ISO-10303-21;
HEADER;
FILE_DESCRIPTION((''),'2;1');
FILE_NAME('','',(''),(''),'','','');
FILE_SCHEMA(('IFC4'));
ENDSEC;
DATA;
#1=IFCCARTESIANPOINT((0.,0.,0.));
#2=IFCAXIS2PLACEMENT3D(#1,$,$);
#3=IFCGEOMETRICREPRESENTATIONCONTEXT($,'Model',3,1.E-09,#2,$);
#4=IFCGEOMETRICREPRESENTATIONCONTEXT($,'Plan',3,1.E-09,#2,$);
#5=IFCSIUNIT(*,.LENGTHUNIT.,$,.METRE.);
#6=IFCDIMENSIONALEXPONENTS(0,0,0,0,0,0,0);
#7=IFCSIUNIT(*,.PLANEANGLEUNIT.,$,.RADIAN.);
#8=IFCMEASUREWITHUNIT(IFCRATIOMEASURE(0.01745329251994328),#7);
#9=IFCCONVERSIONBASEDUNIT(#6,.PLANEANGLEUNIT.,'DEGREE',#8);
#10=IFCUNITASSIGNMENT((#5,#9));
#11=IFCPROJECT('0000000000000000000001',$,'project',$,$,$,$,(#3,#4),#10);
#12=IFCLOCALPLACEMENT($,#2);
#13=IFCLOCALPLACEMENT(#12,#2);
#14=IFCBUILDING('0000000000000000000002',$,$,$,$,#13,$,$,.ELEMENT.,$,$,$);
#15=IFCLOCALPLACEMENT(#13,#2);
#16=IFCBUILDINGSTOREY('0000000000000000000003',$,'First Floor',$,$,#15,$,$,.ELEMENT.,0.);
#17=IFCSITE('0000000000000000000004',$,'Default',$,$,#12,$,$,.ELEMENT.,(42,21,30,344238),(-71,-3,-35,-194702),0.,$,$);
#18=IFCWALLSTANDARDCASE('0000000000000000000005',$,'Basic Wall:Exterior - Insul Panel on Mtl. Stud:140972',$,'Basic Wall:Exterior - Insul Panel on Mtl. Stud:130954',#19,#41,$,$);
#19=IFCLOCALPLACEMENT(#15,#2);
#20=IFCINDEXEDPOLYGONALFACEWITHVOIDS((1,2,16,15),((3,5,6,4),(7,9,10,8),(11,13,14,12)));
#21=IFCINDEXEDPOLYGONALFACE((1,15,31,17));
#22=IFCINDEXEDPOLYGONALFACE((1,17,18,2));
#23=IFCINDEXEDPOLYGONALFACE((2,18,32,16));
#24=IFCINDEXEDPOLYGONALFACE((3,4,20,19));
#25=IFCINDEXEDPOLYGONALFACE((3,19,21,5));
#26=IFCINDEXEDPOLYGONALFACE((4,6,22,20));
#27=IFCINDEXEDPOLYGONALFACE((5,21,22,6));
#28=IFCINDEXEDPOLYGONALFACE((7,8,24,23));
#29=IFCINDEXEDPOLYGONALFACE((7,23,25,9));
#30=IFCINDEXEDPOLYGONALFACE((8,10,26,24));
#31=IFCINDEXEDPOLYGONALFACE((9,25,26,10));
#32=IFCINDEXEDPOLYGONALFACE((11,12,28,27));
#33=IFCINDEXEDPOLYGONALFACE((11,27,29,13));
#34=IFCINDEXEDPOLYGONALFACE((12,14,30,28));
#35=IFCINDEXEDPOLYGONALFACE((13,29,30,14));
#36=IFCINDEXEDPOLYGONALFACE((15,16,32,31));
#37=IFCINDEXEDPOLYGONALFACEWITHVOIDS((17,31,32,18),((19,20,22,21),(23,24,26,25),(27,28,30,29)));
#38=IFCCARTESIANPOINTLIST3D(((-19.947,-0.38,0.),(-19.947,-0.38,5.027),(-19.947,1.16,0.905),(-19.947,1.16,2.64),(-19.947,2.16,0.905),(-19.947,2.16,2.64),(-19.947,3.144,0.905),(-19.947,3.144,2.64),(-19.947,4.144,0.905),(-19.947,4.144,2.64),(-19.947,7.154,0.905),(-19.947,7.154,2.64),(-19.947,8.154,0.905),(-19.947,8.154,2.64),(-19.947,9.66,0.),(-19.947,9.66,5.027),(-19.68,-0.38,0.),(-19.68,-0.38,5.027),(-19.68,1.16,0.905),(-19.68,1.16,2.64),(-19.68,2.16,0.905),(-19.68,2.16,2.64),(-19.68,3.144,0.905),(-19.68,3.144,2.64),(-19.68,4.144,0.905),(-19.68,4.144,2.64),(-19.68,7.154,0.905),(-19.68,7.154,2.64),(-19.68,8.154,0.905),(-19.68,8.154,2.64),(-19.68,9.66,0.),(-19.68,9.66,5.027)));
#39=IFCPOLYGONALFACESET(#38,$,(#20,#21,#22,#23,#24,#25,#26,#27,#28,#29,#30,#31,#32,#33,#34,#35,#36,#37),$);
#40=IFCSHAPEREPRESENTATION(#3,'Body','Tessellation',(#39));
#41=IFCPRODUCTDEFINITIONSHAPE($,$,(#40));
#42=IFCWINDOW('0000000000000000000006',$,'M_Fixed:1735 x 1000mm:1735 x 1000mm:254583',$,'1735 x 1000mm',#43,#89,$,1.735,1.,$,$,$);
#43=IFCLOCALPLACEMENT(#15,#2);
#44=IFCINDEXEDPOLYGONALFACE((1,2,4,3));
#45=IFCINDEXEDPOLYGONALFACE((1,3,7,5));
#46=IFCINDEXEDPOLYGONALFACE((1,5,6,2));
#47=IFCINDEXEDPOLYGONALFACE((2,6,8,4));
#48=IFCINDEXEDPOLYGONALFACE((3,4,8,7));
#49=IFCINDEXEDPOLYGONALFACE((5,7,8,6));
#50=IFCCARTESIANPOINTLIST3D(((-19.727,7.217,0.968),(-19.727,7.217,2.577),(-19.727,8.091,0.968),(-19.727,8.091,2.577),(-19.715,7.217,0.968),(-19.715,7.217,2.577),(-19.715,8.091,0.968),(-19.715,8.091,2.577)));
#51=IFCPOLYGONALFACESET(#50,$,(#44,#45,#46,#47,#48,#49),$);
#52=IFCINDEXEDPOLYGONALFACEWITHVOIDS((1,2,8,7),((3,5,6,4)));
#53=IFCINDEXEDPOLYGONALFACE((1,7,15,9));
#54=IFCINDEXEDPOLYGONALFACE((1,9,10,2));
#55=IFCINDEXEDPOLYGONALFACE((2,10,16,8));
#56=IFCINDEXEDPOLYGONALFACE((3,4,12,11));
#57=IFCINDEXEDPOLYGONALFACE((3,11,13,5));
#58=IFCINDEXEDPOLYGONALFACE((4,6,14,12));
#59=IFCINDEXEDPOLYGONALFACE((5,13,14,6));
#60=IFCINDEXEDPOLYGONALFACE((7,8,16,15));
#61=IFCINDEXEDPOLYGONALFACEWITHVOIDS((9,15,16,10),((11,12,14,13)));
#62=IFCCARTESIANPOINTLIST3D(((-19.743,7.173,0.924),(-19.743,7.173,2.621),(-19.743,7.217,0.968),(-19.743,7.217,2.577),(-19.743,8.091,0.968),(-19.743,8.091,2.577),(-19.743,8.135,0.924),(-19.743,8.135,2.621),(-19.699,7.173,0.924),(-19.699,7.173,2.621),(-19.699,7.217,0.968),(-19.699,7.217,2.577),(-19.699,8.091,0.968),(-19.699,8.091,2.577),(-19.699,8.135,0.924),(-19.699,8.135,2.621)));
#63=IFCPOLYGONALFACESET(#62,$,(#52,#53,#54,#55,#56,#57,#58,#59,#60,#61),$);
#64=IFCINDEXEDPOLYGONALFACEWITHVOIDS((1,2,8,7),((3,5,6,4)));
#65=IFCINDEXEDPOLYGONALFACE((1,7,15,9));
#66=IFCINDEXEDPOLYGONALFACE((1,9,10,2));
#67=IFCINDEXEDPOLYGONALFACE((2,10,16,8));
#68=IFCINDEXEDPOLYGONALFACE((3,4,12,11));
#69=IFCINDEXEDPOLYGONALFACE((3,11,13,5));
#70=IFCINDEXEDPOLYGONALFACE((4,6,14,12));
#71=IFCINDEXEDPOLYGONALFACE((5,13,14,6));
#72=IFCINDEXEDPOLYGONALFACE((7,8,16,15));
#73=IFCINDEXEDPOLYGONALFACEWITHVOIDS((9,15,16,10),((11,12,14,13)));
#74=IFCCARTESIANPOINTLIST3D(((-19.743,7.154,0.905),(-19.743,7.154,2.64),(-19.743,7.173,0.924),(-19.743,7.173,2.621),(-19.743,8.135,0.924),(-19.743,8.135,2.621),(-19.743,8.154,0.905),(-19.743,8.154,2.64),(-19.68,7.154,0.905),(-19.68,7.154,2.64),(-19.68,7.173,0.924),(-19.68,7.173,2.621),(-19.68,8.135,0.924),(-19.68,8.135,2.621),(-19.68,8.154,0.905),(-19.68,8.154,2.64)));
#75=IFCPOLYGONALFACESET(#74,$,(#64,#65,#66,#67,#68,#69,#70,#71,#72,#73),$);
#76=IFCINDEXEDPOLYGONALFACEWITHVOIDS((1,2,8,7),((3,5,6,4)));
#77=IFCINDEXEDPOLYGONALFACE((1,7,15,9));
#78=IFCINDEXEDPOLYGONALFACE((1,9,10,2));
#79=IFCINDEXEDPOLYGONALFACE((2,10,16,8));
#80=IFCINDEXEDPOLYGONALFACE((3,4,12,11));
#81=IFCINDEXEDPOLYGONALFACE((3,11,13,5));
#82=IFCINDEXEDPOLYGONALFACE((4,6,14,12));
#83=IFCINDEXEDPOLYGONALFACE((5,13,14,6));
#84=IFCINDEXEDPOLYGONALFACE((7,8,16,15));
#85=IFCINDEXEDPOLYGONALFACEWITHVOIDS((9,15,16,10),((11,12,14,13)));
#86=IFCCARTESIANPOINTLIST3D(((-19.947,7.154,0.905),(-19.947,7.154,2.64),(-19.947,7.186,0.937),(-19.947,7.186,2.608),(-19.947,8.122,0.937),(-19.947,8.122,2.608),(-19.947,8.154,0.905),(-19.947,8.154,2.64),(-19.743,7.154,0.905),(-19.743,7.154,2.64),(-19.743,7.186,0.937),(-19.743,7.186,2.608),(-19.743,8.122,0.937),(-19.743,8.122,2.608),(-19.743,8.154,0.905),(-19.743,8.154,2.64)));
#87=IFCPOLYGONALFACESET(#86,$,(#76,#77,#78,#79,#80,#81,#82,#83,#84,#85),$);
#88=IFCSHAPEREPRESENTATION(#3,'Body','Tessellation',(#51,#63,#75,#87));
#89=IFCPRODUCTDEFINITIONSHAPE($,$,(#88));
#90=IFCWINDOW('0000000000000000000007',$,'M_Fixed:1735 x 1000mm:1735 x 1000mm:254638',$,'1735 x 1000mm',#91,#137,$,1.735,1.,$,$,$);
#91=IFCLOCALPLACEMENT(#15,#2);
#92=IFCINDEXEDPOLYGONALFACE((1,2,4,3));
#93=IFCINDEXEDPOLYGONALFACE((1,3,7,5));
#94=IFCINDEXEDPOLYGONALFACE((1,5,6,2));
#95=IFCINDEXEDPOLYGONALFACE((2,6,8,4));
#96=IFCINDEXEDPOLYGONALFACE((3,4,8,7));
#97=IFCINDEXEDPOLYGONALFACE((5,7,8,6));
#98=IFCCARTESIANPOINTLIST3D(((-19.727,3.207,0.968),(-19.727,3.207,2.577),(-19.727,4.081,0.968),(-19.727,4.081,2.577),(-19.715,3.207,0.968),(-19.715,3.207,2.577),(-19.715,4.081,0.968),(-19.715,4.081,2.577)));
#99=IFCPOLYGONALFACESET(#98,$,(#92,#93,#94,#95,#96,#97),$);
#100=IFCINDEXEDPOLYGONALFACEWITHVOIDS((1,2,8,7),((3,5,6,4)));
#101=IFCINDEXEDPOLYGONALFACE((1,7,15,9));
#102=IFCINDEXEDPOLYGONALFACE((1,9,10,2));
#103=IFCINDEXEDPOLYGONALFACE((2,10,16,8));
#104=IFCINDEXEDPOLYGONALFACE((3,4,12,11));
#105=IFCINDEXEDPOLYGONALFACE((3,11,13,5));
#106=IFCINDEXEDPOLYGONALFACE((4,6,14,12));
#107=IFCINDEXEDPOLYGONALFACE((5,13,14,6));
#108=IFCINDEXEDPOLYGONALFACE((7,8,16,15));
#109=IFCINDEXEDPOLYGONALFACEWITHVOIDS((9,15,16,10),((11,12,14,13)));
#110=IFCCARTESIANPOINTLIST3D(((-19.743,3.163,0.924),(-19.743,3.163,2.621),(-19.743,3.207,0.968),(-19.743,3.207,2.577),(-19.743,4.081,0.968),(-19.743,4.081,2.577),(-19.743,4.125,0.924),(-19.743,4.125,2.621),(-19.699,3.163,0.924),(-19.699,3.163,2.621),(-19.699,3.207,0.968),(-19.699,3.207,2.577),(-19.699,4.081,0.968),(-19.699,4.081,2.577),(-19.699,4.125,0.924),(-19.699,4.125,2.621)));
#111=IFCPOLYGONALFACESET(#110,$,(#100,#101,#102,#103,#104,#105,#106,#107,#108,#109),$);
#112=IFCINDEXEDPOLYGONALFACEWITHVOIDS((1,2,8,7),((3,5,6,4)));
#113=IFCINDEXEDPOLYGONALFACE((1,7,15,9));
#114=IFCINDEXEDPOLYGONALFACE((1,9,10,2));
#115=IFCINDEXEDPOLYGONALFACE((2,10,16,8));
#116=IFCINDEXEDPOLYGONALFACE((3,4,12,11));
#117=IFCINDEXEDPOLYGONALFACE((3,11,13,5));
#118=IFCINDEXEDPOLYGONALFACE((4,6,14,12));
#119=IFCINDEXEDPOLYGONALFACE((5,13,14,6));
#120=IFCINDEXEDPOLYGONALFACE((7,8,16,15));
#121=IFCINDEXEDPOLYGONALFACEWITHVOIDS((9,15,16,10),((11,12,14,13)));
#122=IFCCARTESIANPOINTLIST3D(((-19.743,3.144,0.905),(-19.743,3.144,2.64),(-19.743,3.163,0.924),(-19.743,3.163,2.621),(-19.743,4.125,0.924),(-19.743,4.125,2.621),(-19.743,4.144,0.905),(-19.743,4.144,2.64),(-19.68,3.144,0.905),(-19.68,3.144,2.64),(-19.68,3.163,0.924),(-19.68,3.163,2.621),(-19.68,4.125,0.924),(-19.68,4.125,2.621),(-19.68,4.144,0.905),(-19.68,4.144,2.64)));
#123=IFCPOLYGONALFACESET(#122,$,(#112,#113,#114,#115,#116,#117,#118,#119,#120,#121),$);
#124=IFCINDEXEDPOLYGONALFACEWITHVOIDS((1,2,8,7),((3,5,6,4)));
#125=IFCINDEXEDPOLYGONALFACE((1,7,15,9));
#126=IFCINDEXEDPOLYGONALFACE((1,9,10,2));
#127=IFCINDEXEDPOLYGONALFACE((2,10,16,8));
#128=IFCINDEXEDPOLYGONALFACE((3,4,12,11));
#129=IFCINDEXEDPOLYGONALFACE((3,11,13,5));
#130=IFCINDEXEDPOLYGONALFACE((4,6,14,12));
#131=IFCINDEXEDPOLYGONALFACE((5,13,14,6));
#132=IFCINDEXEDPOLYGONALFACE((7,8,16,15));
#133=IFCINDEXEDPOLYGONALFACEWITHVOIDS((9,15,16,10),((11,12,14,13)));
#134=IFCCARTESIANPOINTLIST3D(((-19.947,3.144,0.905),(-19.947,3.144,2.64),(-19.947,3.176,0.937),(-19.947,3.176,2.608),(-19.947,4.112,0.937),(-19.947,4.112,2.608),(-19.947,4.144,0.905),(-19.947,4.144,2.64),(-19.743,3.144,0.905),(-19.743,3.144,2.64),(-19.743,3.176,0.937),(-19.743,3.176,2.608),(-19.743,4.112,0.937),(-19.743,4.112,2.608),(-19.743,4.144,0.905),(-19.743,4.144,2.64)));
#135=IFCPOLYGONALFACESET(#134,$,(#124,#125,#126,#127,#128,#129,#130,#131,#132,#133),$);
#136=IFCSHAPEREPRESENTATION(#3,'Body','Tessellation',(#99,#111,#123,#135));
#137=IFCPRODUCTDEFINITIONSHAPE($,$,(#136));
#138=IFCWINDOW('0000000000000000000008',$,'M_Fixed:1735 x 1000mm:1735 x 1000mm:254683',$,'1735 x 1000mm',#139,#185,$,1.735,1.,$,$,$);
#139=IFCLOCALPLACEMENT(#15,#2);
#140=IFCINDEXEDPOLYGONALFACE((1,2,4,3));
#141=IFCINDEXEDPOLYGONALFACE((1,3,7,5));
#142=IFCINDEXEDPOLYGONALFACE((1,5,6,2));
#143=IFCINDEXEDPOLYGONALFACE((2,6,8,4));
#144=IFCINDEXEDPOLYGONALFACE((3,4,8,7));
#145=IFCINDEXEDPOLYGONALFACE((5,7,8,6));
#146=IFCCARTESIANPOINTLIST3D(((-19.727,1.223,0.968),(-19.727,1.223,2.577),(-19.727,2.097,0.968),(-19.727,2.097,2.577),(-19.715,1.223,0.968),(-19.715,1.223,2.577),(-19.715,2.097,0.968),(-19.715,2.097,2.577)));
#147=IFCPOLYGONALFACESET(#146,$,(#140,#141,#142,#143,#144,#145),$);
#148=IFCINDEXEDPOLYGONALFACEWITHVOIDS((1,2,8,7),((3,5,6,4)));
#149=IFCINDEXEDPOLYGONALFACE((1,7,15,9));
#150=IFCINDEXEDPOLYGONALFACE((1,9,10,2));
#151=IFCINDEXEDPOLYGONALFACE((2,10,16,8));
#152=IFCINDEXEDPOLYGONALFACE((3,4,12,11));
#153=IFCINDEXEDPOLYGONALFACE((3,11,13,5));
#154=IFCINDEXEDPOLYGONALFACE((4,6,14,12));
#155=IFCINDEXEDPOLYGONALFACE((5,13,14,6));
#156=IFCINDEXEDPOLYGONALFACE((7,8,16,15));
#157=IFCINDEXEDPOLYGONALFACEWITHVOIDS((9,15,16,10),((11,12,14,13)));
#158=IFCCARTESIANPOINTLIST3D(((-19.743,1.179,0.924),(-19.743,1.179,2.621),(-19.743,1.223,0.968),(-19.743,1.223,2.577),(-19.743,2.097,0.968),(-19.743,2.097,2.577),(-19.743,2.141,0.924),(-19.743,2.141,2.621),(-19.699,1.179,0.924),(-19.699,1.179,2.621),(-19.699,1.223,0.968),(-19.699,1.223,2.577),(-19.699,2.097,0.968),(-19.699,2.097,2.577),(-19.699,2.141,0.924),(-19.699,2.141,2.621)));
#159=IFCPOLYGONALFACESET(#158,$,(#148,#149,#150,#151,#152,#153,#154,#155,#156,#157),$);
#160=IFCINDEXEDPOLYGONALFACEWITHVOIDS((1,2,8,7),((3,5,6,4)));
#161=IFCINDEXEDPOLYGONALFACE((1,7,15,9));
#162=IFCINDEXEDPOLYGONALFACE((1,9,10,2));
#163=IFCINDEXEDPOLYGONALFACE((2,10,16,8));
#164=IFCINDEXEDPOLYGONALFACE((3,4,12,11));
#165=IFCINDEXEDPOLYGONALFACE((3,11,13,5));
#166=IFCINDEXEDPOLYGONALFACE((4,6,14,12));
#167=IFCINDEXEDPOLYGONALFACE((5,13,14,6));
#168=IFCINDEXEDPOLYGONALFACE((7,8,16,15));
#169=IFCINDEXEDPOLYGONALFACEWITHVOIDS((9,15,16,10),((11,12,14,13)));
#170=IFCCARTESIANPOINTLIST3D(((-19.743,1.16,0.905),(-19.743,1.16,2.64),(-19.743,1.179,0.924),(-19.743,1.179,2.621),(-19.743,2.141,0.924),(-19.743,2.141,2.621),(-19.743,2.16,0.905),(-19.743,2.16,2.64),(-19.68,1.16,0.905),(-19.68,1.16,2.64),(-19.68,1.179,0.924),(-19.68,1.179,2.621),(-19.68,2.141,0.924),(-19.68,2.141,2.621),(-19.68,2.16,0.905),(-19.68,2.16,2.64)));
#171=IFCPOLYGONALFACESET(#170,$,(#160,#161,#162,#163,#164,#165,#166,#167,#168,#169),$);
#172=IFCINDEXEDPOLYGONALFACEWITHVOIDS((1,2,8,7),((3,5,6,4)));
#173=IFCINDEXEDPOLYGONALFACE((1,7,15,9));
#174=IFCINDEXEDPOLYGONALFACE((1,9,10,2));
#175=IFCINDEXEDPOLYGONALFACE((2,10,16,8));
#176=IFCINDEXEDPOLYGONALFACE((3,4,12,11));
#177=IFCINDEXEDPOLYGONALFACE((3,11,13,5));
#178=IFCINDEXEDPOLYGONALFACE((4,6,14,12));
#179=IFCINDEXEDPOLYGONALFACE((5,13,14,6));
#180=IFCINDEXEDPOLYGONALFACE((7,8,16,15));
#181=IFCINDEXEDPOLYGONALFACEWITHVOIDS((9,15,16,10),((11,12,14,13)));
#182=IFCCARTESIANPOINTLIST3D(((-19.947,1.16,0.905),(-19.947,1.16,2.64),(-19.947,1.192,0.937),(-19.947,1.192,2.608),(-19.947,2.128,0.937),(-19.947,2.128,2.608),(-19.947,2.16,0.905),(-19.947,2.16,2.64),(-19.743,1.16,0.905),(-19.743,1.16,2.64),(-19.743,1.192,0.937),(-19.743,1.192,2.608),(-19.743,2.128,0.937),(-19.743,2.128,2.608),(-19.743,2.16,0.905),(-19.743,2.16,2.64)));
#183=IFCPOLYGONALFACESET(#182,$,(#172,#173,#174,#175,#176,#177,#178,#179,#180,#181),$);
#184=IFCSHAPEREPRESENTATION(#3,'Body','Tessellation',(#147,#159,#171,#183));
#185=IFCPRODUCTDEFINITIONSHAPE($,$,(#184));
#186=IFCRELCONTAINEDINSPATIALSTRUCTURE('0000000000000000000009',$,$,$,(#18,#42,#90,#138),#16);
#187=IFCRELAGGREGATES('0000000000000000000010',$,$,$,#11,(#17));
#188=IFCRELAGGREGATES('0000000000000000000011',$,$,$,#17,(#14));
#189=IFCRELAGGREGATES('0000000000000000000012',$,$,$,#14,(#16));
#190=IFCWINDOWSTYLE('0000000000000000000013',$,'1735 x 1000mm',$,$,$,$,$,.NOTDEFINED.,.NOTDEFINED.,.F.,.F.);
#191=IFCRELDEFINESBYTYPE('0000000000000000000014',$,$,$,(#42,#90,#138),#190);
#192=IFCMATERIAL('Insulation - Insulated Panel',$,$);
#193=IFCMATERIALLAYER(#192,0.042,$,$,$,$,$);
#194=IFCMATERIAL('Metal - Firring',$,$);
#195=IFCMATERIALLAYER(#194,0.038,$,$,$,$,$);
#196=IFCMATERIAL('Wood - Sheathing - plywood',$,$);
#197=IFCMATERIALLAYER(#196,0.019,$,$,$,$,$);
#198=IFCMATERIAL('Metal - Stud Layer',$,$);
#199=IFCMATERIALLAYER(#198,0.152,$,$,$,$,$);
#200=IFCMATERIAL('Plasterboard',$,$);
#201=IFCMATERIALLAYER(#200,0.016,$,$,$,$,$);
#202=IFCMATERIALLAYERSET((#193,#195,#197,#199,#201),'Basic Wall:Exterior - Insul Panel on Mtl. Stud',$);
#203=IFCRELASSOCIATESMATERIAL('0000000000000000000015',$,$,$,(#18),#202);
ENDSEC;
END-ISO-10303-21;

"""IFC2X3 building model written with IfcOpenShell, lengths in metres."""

from ifc_helpers import new_model, entity, si_unit, converted_unit, frame, frame_2d, origin, origin_2d_with_axis, place, context, project, spatial, polyline, rectangle, outline, extrude, source, transform, mapped, material, layer, layer_set, layer_usage, type_object, type_shapes, element, fill, save


model = new_model("IFC2X3")

# Units and contexts
model_context = context("Model", 3, precision=1e-09, world=origin())
plan_context = context("Plan", 3, precision=1e-09, world=origin())
ifc_project = project(units=[si_unit("LENGTHUNIT", "METRE"), converted_unit("PLANEANGLEUNIT", "DEGREE", entity("IfcRatioMeasure", 0.01745329251994328), si_unit("PLANEANGLEUNIT", "RADIAN"), dimensions=[0, 0, 0, 0, 0, 0, 0])], contexts=[model_context, plan_context])

# Site, building, storey
site_placement = place(None, origin())
site = spatial("IfcSite", under=ifc_project, at=site_placement, Name="Default", CompositionType="ELEMENT", RefLatitude=(42, 21, 30, 344238), RefLongitude=(-71, -3, -35, -194702), RefElevation=0.0)
building_placement = place(site_placement, origin())
building = spatial("IfcBuilding", under=site, at=building_placement, CompositionType="ELEMENT")
storey_placement = place(building_placement, origin())
storey = spatial("IfcBuildingStorey", under=building, at=storey_placement, Name="First Floor", CompositionType="ELEMENT", Elevation=0.0)

# Shared definitions
ifc_material_1 = material(Name="Insulation - Insulated Panel")
ifc_layer_1 = layer(ifc_material_1, 0.042)
ifc_material_2 = material(Name="Metal - Firring")
ifc_layer_2 = layer(ifc_material_2, 0.038)
ifc_material_3 = material(Name="Wood - Sheathing - plywood")
ifc_layer_3 = layer(ifc_material_3, 0.019)
ifc_material_4 = material(Name="Metal - Stud Layer")
ifc_layer_4 = layer(ifc_material_4, 0.152)
ifc_material_5 = material(Name="Plasterboard")
ifc_layer_5 = layer(ifc_material_5, 0.016)
ifc_layer_set_1 = layer_set([ifc_layer_1, ifc_layer_2, ifc_layer_3, ifc_layer_4, ifc_layer_5], Name="Basic Wall:Exterior - Insul Panel on Mtl. Stud")
ifc_layer_usage_1 = layer_usage(ifc_layer_set_1, "AXIS2", "NEGATIVE", 0.1335)

# Wall, openings, windows
wall_1_placement = place(storey_placement, frame((-19.8135, 9.66, 0.0), z_axis=(0.0, 0.0, 1.0), x_axis=(0.0, -1.0, 0.0)))
wall_1 = element("IfcWallStandardCase", 1, at=wall_1_placement, inside=storey, material=ifc_layer_usage_1, Name="Basic Wall:Exterior - Insul Panel on Mtl. Stud:140972", ObjectType="Basic Wall:Exterior - Insul Panel on Mtl. Stud:130954", context=model_context, shape_type="SweptSolid", body=[
    extrude(rectangle(XDim=10.04, YDim=0.267, at=frame_2d((5.02, 0.0), x_axis=(-1.0, 0.0))), origin(), (0.0, 0.0, 1.0), 5.027),
])
opening_1_placement = place(wall_1_placement, frame((1.506, -0.1335, 0.905)))
opening_1 = element("IfcOpeningElement", 2, at=opening_1_placement, cuts=wall_1, ObjectType="Opening", context=model_context, shape_type="SweptSolid", body=[
    extrude(rectangle(XDim=1.735, YDim=1.0, at=frame_2d((0.8675, 0.5), x_axis=(1.0, 0.0))), frame((0.0, 0.0, 0.0), z_axis=(0.0, 1.0, 0.0), x_axis=(0.0, 0.0, 1.0)), (0.0, 0.0, 1.0), 0.267),
])
opening_2_placement = place(wall_1_placement, frame((5.516, -0.1335, 0.905)))
opening_2 = element("IfcOpeningElement", 3, at=opening_2_placement, cuts=wall_1, ObjectType="Opening", context=model_context, shape_type="SweptSolid", body=[
    extrude(rectangle(XDim=1.735, YDim=1.0, at=frame_2d((0.8675, 0.5), x_axis=(1.0, 0.0))), frame((0.0, 0.0, 0.0), z_axis=(0.0, 1.0, 0.0), x_axis=(0.0, 0.0, 1.0)), (0.0, 0.0, 1.0), 0.267),
])
opening_3_placement = place(wall_1_placement, frame((7.5, -0.1335, 0.905)))
opening_3 = element("IfcOpeningElement", 4, at=opening_3_placement, cuts=wall_1, ObjectType="Opening", context=model_context, shape_type="SweptSolid", body=[
    extrude(rectangle(XDim=1.735, YDim=1.0, at=frame_2d((0.8675, 0.5), x_axis=(1.0, 0.0))), frame((0.0, 0.0, 0.0), z_axis=(0.0, 1.0, 0.0), x_axis=(0.0, 0.0, 1.0)), (0.0, 0.0, 1.0), 0.267),
])
window_style = type_object("IfcWindowStyle", Name="1735 x 1000mm", ConstructionType="NOTDEFINED", OperationType="NOTDEFINED", ParameterTakesPrecedence=False, Sizeable=False)
shared_shape_1 = source(origin(), model_context, "Body", "SweptSolid", [
    extrude(rectangle(XDim=0.012, YDim=0.874, at=origin_2d_with_axis()), frame((0.5, 0.226, 0.063), z_axis=(0.0, 0.0, 1.0), x_axis=(0.0, -1.0, 0.0)), (0.0, 0.0, 1.0), 1.609),
    extrude(outline(polyline([(-0.481, -0.8485), (0.481, -0.8485), (0.481, 0.8485), (-0.481, 0.8485), (-0.481, -0.8485)]), holes=[polyline([(-0.437, -0.8045), (-0.437, 0.8045), (0.437, 0.8045), (0.437, -0.8045), (-0.437, -0.8045)])]), frame((0.5, 0.204, 0.8675), z_axis=(0.0, 1.0, 0.0), x_axis=(1.0, 0.0, 0.0)), (0.0, 0.0, 1.0), 0.044),
    extrude(outline(polyline([(-0.5, -0.8675), (0.5, -0.8675), (0.5, 0.8675), (-0.5, 0.8675), (-0.5, -0.8675)]), holes=[polyline([(-0.481, -0.8485), (-0.481, 0.8485), (0.481, 0.8485), (0.481, -0.8485), (-0.481, -0.8485)])]), frame((0.5, 0.204, 0.8675), z_axis=(0.0, 1.0, 0.0), x_axis=(1.0, 0.0, 0.0)), (0.0, 0.0, 1.0), 0.063),
    extrude(outline(polyline([(-0.5, -0.8675), (0.5, -0.8675), (0.5, 0.8675), (-0.5, 0.8675), (-0.5, -0.8675)]), holes=[polyline([(-0.468, -0.8355), (-0.468, 0.8355), (0.468, 0.8355), (0.468, -0.8355), (-0.468, -0.8355)])]), frame((0.5, 0.0, 0.8675), z_axis=(0.0, 1.0, 0.0), x_axis=(1.0, 0.0, 0.0)), (0.0, 0.0, 1.0), 0.204),
])
type_shapes(window_style, [shared_shape_1])
window_1_placement = place(opening_1_placement, origin())
window_1 = element("IfcWindow", 5, at=window_1_placement, inside=storey, type_object=window_style, Name="M_Fixed:1735 x 1000mm:1735 x 1000mm:254583", ObjectType="1735 x 1000mm", OverallHeight=1.735, OverallWidth=1.0, context=model_context, shape_type="MappedRepresentation", body=[
    mapped(shared_shape_1, transform((0.0, 0.0, 0.0), scale=1.0)),
])
fill(opening_1, window_1)
window_2_placement = place(opening_2_placement, origin())
window_2 = element("IfcWindow", 6, at=window_2_placement, inside=storey, type_object=window_style, Name="M_Fixed:1735 x 1000mm:1735 x 1000mm:254638", ObjectType="1735 x 1000mm", OverallHeight=1.735, OverallWidth=1.0, context=model_context, shape_type="MappedRepresentation", body=[
    mapped(shared_shape_1, transform((0.0, 0.0, 0.0), scale=1.0)),
])
fill(opening_2, window_2)
window_3_placement = place(opening_3_placement, origin())
window_3 = element("IfcWindow", 7, at=window_3_placement, inside=storey, type_object=window_style, Name="M_Fixed:1735 x 1000mm:1735 x 1000mm:254683", ObjectType="1735 x 1000mm", OverallHeight=1.735, OverallWidth=1.0, context=model_context, shape_type="MappedRepresentation", body=[
    mapped(shared_shape_1, transform((0.0, 0.0, 0.0), scale=1.0)),
])
fill(opening_3, window_3)

save(model, "model.ifc")
